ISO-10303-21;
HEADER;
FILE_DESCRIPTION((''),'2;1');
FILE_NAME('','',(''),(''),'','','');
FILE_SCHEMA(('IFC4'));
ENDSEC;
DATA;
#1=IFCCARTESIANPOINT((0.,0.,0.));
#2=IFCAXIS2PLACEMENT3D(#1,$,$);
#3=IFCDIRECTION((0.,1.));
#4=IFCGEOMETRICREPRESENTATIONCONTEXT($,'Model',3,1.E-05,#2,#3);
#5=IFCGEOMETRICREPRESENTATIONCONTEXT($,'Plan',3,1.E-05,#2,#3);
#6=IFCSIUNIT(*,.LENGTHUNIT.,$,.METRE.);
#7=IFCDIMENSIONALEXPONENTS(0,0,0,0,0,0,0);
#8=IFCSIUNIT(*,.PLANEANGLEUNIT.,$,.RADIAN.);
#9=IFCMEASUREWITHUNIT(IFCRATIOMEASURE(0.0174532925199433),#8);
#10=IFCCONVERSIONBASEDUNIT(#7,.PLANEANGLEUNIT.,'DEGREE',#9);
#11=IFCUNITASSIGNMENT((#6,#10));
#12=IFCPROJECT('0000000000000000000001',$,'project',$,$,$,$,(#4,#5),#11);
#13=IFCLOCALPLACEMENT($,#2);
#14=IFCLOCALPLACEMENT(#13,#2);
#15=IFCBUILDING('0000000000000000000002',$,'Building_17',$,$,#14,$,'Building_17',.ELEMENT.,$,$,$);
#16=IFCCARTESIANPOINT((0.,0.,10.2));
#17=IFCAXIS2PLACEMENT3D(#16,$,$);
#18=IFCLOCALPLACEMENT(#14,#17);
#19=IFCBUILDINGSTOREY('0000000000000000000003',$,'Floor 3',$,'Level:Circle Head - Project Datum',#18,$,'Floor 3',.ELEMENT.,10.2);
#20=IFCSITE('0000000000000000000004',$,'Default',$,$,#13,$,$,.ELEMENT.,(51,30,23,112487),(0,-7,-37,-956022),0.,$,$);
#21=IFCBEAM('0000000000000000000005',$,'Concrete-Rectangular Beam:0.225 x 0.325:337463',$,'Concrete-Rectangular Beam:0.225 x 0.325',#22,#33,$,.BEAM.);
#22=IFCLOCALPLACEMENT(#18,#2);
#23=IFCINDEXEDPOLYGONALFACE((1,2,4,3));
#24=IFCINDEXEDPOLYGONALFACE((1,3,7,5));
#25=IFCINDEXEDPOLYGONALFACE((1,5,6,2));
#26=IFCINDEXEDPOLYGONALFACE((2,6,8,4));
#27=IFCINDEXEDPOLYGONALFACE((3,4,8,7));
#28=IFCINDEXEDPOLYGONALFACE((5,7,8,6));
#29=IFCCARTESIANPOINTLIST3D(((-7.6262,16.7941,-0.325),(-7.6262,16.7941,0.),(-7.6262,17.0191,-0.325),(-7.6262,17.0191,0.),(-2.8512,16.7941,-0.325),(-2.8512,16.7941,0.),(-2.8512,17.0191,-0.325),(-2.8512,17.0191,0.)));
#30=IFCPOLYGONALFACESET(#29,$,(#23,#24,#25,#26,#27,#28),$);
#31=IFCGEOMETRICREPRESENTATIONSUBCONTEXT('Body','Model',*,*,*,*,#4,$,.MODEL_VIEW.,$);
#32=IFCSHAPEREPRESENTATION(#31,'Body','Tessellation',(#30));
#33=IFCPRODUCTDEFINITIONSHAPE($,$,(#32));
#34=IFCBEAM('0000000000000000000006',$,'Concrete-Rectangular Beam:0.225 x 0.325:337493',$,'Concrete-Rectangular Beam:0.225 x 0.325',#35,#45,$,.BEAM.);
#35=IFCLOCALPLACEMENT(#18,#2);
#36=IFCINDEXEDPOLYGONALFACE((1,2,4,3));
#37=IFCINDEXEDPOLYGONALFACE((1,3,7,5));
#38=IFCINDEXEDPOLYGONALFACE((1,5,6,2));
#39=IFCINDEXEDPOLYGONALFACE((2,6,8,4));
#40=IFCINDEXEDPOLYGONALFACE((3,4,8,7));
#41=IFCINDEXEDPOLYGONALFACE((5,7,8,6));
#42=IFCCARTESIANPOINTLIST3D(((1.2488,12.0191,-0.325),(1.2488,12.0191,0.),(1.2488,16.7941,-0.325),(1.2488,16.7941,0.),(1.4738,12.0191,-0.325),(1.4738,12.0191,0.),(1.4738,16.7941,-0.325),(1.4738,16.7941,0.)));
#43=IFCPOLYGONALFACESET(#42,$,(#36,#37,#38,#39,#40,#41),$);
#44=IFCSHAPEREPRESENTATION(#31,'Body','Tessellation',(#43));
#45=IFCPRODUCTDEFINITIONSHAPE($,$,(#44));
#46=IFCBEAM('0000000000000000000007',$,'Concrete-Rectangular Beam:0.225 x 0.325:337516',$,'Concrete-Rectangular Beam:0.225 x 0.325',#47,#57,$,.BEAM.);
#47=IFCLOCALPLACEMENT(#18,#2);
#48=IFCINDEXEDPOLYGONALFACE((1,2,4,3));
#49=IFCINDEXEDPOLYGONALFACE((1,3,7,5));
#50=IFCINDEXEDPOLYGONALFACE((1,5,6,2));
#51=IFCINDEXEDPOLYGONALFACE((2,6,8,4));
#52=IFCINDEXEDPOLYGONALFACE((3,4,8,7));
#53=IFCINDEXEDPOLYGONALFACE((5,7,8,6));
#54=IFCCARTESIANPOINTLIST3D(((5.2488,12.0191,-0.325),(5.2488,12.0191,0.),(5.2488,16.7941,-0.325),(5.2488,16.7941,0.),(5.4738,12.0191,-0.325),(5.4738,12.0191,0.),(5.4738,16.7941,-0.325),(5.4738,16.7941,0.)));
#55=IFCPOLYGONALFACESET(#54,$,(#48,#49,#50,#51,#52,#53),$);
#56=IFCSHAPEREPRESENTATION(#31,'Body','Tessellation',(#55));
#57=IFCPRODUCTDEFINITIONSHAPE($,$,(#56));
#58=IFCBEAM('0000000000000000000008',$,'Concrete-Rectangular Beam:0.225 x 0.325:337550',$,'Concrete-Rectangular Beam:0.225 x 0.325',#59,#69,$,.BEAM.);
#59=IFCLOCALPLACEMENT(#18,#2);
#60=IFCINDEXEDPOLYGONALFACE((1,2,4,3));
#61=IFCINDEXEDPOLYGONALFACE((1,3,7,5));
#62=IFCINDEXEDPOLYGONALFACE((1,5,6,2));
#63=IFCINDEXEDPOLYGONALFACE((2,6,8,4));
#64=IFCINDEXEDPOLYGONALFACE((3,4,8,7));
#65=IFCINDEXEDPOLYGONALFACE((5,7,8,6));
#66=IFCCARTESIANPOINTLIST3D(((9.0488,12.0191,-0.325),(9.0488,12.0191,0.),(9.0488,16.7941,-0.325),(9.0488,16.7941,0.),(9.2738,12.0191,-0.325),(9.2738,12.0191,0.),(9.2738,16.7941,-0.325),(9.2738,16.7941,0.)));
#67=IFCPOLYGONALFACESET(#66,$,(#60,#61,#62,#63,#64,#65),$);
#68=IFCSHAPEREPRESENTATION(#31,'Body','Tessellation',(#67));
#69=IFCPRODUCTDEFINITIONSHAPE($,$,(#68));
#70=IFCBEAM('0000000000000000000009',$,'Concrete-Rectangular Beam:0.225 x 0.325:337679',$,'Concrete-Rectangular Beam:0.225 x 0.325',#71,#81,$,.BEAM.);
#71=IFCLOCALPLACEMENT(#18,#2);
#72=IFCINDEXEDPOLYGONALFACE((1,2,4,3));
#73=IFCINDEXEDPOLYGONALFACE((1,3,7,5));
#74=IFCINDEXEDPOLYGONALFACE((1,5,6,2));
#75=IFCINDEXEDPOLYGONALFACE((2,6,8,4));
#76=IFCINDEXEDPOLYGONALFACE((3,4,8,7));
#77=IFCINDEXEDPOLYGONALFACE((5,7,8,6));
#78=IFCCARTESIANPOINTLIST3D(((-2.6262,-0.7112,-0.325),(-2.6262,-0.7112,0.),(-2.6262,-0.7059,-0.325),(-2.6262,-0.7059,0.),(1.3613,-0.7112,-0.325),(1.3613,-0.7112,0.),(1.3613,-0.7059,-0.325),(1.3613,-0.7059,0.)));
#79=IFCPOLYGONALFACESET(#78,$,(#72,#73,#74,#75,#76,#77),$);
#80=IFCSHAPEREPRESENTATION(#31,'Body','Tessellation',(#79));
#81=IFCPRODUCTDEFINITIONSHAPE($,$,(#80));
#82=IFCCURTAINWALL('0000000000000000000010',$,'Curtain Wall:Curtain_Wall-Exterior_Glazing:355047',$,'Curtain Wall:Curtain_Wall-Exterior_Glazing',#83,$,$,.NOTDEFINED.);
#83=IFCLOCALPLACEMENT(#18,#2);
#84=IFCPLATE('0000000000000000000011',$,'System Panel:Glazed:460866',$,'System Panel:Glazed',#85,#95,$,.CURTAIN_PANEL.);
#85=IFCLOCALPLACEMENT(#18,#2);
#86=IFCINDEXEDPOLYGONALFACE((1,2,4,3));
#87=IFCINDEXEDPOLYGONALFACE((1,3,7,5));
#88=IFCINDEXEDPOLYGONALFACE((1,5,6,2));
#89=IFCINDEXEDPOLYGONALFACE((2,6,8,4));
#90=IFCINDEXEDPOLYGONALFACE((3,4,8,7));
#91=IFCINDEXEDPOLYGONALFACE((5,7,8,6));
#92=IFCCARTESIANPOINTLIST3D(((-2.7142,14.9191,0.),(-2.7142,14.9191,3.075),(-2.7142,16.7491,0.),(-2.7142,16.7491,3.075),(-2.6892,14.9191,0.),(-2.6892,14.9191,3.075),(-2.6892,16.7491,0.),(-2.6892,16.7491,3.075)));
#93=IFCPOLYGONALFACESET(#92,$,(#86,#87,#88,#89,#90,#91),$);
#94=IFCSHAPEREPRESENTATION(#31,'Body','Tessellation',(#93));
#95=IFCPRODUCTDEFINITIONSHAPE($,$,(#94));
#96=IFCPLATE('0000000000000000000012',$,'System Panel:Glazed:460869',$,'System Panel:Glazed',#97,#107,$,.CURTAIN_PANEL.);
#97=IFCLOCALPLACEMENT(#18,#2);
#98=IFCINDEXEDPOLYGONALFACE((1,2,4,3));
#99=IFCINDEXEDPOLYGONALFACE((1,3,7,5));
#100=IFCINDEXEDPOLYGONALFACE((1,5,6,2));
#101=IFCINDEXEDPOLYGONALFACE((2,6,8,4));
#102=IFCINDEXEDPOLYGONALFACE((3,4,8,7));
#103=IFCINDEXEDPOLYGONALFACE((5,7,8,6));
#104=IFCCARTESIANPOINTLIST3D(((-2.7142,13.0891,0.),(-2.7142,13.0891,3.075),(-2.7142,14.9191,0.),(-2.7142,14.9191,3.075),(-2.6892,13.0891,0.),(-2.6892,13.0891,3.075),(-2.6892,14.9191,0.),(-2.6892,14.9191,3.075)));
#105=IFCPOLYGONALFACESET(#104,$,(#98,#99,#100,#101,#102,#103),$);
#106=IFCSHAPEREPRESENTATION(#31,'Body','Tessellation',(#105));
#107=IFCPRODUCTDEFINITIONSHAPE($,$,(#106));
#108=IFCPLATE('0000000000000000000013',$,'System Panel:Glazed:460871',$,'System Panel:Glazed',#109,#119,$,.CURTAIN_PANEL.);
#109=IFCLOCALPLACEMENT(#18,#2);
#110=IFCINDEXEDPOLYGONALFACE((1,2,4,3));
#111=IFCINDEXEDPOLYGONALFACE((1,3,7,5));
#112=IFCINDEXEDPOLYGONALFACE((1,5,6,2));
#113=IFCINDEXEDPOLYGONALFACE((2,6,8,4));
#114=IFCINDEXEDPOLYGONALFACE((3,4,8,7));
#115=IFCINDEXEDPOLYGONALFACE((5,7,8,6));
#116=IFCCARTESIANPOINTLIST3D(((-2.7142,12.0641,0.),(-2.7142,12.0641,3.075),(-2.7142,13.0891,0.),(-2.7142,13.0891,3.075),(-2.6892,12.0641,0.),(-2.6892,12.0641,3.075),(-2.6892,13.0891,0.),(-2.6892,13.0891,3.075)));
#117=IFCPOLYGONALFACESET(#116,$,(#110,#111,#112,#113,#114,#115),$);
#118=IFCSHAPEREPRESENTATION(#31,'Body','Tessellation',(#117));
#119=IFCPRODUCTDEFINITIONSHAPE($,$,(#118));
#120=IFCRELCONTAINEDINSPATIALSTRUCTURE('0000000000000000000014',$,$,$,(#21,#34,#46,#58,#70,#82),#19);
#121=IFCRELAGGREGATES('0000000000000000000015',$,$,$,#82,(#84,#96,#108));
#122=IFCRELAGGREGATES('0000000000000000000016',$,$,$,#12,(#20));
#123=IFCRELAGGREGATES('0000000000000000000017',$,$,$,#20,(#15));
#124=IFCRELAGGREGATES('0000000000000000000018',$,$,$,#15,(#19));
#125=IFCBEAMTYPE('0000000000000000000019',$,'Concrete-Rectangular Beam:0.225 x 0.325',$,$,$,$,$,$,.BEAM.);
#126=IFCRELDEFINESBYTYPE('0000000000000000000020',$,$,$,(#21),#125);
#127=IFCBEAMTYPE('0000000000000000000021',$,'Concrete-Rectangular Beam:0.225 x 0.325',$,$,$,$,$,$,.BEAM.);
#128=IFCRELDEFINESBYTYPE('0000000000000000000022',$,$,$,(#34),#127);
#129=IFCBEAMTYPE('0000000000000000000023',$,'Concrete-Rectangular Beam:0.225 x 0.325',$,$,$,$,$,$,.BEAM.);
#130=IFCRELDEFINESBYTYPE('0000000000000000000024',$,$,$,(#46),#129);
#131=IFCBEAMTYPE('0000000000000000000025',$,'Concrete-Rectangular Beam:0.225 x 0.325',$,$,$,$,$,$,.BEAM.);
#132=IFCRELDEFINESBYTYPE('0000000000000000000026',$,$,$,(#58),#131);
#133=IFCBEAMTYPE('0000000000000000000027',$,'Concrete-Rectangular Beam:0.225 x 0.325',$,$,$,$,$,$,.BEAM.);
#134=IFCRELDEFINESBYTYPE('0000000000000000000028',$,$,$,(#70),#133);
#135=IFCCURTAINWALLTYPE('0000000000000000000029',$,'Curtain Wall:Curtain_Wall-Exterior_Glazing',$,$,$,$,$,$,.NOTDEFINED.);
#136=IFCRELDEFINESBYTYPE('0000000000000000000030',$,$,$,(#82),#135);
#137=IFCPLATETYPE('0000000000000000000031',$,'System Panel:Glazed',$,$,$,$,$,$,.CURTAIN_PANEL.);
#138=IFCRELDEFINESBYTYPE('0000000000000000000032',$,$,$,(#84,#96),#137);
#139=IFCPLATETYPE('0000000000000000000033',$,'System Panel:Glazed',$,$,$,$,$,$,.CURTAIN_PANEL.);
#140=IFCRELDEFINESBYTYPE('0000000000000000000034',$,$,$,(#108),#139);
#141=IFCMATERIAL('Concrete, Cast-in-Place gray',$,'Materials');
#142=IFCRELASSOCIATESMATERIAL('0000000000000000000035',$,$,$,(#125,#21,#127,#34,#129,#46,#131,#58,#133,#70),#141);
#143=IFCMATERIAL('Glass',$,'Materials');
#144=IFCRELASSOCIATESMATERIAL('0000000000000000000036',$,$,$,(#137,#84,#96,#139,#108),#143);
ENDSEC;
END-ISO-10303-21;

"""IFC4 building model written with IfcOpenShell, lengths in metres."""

from ifc_helpers import new_model, entity, si_unit, converted_unit, direction, frame, origin, place, context, subcontext, project, spatial, indexed_curve, outline, extrude, source, transform, mapped, material, type_object, type_shapes, element, aggregate, save


model = new_model("IFC4")

# Units and contexts
model_context = context("Model", 3, precision=1e-05, world=origin(), true_north=direction((0.0, 1.0)))
plan_context = context("Plan", 3, precision=1e-05, world=origin(), true_north=direction((0.0, 1.0)))
body_context = subcontext(model_context, "Body", "Model", "MODEL_VIEW")
ifc_project = project(units=[si_unit("LENGTHUNIT", "METRE"), converted_unit("PLANEANGLEUNIT", "DEGREE", entity("IfcRatioMeasure", 0.0174532925199433), si_unit("PLANEANGLEUNIT", "RADIAN"), dimensions=[0, 0, 0, 0, 0, 0, 0])], contexts=[model_context, plan_context])

# Site, building, storey
site_placement = place(None, origin())
site = spatial("IfcSite", under=ifc_project, at=site_placement, Name="Default", CompositionType="ELEMENT", RefLatitude=(51, 30, 23, 112487), RefLongitude=(0, -7, -37, -956022), RefElevation=0.0)
building_placement = place(site_placement, origin())
building = spatial("IfcBuilding", under=site, at=building_placement, Name="Building_17", LongName="Building_17", CompositionType="ELEMENT")
storey_placement = place(building_placement, frame((0.0, 0.0, 10.2)))
storey = spatial("IfcBuildingStorey", under=building, at=storey_placement, Name="Floor 3", ObjectType="Level:Circle Head - Project Datum", LongName="Floor 3", CompositionType="ELEMENT", Elevation=10.2)

# Beams
ifc_material_1 = material(Name="Concrete, Cast-in-Place gray", Category="Materials")
beam_type_1 = type_object("IfcBeamType", Name="Concrete-Rectangular Beam:0.225 x 0.325", PredefinedType="BEAM", material=ifc_material_1)
shared_shape_1 = source(origin(), body_context, "Body", "SweptSolid", [
    extrude(outline(indexed_curve([(-0.1625, -0.1125), (0.1625, -0.1125), (0.1625, 0.1125), (-0.1625, 0.1125), (-0.1625, -0.1125)], self_intersect=False)), frame((-7.6262, 16.9066, 10.0375), z_axis=(1.0, 0.0, 0.0), x_axis=(0.0, 0.0, -1.0)), (0.0, 0.0, 1.0), 4.775),
])
type_shapes(beam_type_1, [shared_shape_1])
beam_1_placement = place(storey_placement, frame((0.0, 0.0, -10.2)))
element("IfcBeam", 1, at=beam_1_placement, inside=storey, type_object=beam_type_1, material=ifc_material_1, Name="Concrete-Rectangular Beam:0.225 x 0.325:337463", ObjectType="Concrete-Rectangular Beam:0.225 x 0.325", PredefinedType="BEAM", context=body_context, shape_type="MappedRepresentation", body=[
    mapped(shared_shape_1, transform((0.0, 0.0, 0.0), scale=1.0)),
])
beam_type_2 = type_object("IfcBeamType", Name="Concrete-Rectangular Beam:0.225 x 0.325", PredefinedType="BEAM", material=ifc_material_1)
shared_shape_2 = source(origin(), body_context, "Body", "SweptSolid", [
    extrude(outline(indexed_curve([(-0.1125, -0.1625), (0.1125, -0.1625), (0.1125, 0.1625), (-0.1125, 0.1625), (-0.1125, -0.1625)], self_intersect=False)), frame((1.3613, 16.7941, 10.0375), z_axis=(0.0, -1.0, 0.0), x_axis=(-1.0, 0.0, 0.0)), (0.0, 0.0, 1.0), 4.775),
])
type_shapes(beam_type_2, [shared_shape_2])
beam_2_placement = place(storey_placement, frame((0.0, 0.0, -10.2)))
element("IfcBeam", 2, at=beam_2_placement, inside=storey, type_object=beam_type_2, material=ifc_material_1, Name="Concrete-Rectangular Beam:0.225 x 0.325:337493", ObjectType="Concrete-Rectangular Beam:0.225 x 0.325", PredefinedType="BEAM", context=body_context, shape_type="MappedRepresentation", body=[
    mapped(shared_shape_2, transform((0.0, 0.0, 0.0), scale=1.0)),
])
beam_type_3 = type_object("IfcBeamType", Name="Concrete-Rectangular Beam:0.225 x 0.325", PredefinedType="BEAM", material=ifc_material_1)
shared_shape_3 = source(origin(), body_context, "Body", "SweptSolid", [
    extrude(outline(indexed_curve([(-0.1125, -0.1625), (0.1125, -0.1625), (0.1125, 0.1625), (-0.1125, 0.1625), (-0.1125, -0.1625)], self_intersect=False)), frame((5.3613, 16.7941, 10.0375), z_axis=(0.0, -1.0, 0.0), x_axis=(-1.0, 0.0, 0.0)), (0.0, 0.0, 1.0), 4.775),
])
type_shapes(beam_type_3, [shared_shape_3])
beam_3_placement = place(storey_placement, frame((0.0, 0.0, -10.2)))
element("IfcBeam", 3, at=beam_3_placement, inside=storey, type_object=beam_type_3, material=ifc_material_1, Name="Concrete-Rectangular Beam:0.225 x 0.325:337516", ObjectType="Concrete-Rectangular Beam:0.225 x 0.325", PredefinedType="BEAM", context=body_context, shape_type="MappedRepresentation", body=[
    mapped(shared_shape_3, transform((0.0, 0.0, 0.0), scale=1.0)),
])
beam_type_4 = type_object("IfcBeamType", Name="Concrete-Rectangular Beam:0.225 x 0.325", PredefinedType="BEAM", material=ifc_material_1)
shared_shape_4 = source(origin(), body_context, "Body", "SweptSolid", [
    extrude(outline(indexed_curve([(-0.1125, -0.1625), (0.1125, -0.1625), (0.1125, 0.1625), (-0.1125, 0.1625), (-0.1125, -0.1625)], self_intersect=False)), frame((9.1613, 16.7941, 10.0375), z_axis=(0.0, -1.0, 0.0), x_axis=(-1.0, 0.0, 0.0)), (0.0, 0.0, 1.0), 4.775),
])
type_shapes(beam_type_4, [shared_shape_4])
beam_4_placement = place(storey_placement, frame((0.0, 0.0, -10.2)))
element("IfcBeam", 4, at=beam_4_placement, inside=storey, type_object=beam_type_4, material=ifc_material_1, Name="Concrete-Rectangular Beam:0.225 x 0.325:337550", ObjectType="Concrete-Rectangular Beam:0.225 x 0.325", PredefinedType="BEAM", context=body_context, shape_type="MappedRepresentation", body=[
    mapped(shared_shape_4, transform((0.0, 0.0, 0.0), scale=1.0)),
])
beam_type_5 = type_object("IfcBeamType", Name="Concrete-Rectangular Beam:0.225 x 0.325", PredefinedType="BEAM", material=ifc_material_1)
shared_shape_5 = source(origin(), body_context, "Body", "SweptSolid", [
    extrude(outline(indexed_curve([(-0.1625, -0.0026), (0.1625, -0.0026), (0.1625, 0.0026), (-0.1625, 0.0026), (-0.1625, -0.0026)], self_intersect=False)), frame((-2.6262, -0.7085, 10.0375), z_axis=(1.0, 0.0, 0.0), x_axis=(0.0, 0.0, -1.0)), (0.0, 0.0, 1.0), 3.9875),
])
type_shapes(beam_type_5, [shared_shape_5])
beam_5_placement = place(storey_placement, frame((0.0, 0.0, -10.2)))
element("IfcBeam", 5, at=beam_5_placement, inside=storey, type_object=beam_type_5, material=ifc_material_1, Name="Concrete-Rectangular Beam:0.225 x 0.325:337679", ObjectType="Concrete-Rectangular Beam:0.225 x 0.325", PredefinedType="BEAM", context=body_context, shape_type="MappedRepresentation", body=[
    mapped(shared_shape_5, transform((0.0, 0.0, 0.0), scale=1.0)),
])

# Curtain wall, plates
curtain_wall_type = type_object("IfcCurtainWallType", Name="Curtain Wall:Curtain_Wall-Exterior_Glazing", PredefinedType="NOTDEFINED")
curtain_wall_placement = place(storey_placement, frame((0.0, 0.0, -10.2)))
curtain_wall = element("IfcCurtainWall", 6, at=curtain_wall_placement, inside=storey, type_object=curtain_wall_type, Name="Curtain Wall:Curtain_Wall-Exterior_Glazing:355047", ObjectType="Curtain Wall:Curtain_Wall-Exterior_Glazing", PredefinedType="NOTDEFINED")
ifc_material_2 = material(Name="Glass", Category="Materials")
plate_type_1 = type_object("IfcPlateType", Name="System Panel:Glazed", PredefinedType="CURTAIN_PANEL", material=ifc_material_2)
shared_shape_6 = source(origin(), body_context, "Body", "SweptSolid", [
    extrude(outline(indexed_curve([(-0.0125, -0.915), (0.0125, -0.915), (0.0125, 0.915), (-0.0125, 0.915), (-0.0125, -0.915)], self_intersect=False)), frame((0.0, 0.037, 0.0), z_axis=(0.0, 0.0, 1.0), x_axis=(0.0, 1.0, 0.0)), (0.0, 0.0, 1.0), 3.075),
])
type_shapes(plate_type_1, [shared_shape_6])
plate_1_placement = place(curtain_wall_placement, frame((-2.7387, 15.8341, 10.2), z_axis=(0.0, 0.0, 1.0), x_axis=(0.0, -1.0, 0.0)))
plate_1 = element("IfcPlate", 7, at=plate_1_placement, type_object=plate_type_1, material=ifc_material_2, Name="System Panel:Glazed:460866", ObjectType="System Panel:Glazed", PredefinedType="CURTAIN_PANEL", context=body_context, shape_type="MappedRepresentation", body=[
    mapped(shared_shape_6, transform((0.0, 0.0, 0.0), scale=1.0)),
])
plate_2_placement = place(curtain_wall_placement, frame((-2.7387, 14.0041, 10.2), z_axis=(0.0, 0.0, 1.0), x_axis=(0.0, -1.0, 0.0)))
plate_2 = element("IfcPlate", 8, at=plate_2_placement, type_object=plate_type_1, material=ifc_material_2, Name="System Panel:Glazed:460869", ObjectType="System Panel:Glazed", PredefinedType="CURTAIN_PANEL", context=body_context, shape_type="MappedRepresentation", body=[
    mapped(shared_shape_6, transform((0.0, 0.0, 0.0), scale=1.0)),
])
plate_type_2 = type_object("IfcPlateType", Name="System Panel:Glazed", PredefinedType="CURTAIN_PANEL", material=ifc_material_2)
shared_shape_7 = source(origin(), body_context, "Body", "SweptSolid", [
    extrude(outline(indexed_curve([(-0.0125, -0.5125), (0.0125, -0.5125), (0.0125, 0.5125), (-0.0125, 0.5125), (-0.0125, -0.5125)], self_intersect=False)), frame((0.0, 0.037, 0.0), z_axis=(0.0, 0.0, 1.0), x_axis=(0.0, 1.0, 0.0)), (0.0, 0.0, 1.0), 3.075),
])
type_shapes(plate_type_2, [shared_shape_7])
plate_3_placement = place(curtain_wall_placement, frame((-2.7387, 12.5766, 10.2), z_axis=(0.0, 0.0, 1.0), x_axis=(0.0, -1.0, 0.0)))
plate_3 = element("IfcPlate", 9, at=plate_3_placement, type_object=plate_type_2, material=ifc_material_2, Name="System Panel:Glazed:460871", ObjectType="System Panel:Glazed", PredefinedType="CURTAIN_PANEL", context=body_context, shape_type="MappedRepresentation", body=[
    mapped(shared_shape_7, transform((0.0, 0.0, 0.0), scale=1.0)),
])
aggregate(curtain_wall, [plate_1, plate_2, plate_3])

save(model, "model.ifc")
